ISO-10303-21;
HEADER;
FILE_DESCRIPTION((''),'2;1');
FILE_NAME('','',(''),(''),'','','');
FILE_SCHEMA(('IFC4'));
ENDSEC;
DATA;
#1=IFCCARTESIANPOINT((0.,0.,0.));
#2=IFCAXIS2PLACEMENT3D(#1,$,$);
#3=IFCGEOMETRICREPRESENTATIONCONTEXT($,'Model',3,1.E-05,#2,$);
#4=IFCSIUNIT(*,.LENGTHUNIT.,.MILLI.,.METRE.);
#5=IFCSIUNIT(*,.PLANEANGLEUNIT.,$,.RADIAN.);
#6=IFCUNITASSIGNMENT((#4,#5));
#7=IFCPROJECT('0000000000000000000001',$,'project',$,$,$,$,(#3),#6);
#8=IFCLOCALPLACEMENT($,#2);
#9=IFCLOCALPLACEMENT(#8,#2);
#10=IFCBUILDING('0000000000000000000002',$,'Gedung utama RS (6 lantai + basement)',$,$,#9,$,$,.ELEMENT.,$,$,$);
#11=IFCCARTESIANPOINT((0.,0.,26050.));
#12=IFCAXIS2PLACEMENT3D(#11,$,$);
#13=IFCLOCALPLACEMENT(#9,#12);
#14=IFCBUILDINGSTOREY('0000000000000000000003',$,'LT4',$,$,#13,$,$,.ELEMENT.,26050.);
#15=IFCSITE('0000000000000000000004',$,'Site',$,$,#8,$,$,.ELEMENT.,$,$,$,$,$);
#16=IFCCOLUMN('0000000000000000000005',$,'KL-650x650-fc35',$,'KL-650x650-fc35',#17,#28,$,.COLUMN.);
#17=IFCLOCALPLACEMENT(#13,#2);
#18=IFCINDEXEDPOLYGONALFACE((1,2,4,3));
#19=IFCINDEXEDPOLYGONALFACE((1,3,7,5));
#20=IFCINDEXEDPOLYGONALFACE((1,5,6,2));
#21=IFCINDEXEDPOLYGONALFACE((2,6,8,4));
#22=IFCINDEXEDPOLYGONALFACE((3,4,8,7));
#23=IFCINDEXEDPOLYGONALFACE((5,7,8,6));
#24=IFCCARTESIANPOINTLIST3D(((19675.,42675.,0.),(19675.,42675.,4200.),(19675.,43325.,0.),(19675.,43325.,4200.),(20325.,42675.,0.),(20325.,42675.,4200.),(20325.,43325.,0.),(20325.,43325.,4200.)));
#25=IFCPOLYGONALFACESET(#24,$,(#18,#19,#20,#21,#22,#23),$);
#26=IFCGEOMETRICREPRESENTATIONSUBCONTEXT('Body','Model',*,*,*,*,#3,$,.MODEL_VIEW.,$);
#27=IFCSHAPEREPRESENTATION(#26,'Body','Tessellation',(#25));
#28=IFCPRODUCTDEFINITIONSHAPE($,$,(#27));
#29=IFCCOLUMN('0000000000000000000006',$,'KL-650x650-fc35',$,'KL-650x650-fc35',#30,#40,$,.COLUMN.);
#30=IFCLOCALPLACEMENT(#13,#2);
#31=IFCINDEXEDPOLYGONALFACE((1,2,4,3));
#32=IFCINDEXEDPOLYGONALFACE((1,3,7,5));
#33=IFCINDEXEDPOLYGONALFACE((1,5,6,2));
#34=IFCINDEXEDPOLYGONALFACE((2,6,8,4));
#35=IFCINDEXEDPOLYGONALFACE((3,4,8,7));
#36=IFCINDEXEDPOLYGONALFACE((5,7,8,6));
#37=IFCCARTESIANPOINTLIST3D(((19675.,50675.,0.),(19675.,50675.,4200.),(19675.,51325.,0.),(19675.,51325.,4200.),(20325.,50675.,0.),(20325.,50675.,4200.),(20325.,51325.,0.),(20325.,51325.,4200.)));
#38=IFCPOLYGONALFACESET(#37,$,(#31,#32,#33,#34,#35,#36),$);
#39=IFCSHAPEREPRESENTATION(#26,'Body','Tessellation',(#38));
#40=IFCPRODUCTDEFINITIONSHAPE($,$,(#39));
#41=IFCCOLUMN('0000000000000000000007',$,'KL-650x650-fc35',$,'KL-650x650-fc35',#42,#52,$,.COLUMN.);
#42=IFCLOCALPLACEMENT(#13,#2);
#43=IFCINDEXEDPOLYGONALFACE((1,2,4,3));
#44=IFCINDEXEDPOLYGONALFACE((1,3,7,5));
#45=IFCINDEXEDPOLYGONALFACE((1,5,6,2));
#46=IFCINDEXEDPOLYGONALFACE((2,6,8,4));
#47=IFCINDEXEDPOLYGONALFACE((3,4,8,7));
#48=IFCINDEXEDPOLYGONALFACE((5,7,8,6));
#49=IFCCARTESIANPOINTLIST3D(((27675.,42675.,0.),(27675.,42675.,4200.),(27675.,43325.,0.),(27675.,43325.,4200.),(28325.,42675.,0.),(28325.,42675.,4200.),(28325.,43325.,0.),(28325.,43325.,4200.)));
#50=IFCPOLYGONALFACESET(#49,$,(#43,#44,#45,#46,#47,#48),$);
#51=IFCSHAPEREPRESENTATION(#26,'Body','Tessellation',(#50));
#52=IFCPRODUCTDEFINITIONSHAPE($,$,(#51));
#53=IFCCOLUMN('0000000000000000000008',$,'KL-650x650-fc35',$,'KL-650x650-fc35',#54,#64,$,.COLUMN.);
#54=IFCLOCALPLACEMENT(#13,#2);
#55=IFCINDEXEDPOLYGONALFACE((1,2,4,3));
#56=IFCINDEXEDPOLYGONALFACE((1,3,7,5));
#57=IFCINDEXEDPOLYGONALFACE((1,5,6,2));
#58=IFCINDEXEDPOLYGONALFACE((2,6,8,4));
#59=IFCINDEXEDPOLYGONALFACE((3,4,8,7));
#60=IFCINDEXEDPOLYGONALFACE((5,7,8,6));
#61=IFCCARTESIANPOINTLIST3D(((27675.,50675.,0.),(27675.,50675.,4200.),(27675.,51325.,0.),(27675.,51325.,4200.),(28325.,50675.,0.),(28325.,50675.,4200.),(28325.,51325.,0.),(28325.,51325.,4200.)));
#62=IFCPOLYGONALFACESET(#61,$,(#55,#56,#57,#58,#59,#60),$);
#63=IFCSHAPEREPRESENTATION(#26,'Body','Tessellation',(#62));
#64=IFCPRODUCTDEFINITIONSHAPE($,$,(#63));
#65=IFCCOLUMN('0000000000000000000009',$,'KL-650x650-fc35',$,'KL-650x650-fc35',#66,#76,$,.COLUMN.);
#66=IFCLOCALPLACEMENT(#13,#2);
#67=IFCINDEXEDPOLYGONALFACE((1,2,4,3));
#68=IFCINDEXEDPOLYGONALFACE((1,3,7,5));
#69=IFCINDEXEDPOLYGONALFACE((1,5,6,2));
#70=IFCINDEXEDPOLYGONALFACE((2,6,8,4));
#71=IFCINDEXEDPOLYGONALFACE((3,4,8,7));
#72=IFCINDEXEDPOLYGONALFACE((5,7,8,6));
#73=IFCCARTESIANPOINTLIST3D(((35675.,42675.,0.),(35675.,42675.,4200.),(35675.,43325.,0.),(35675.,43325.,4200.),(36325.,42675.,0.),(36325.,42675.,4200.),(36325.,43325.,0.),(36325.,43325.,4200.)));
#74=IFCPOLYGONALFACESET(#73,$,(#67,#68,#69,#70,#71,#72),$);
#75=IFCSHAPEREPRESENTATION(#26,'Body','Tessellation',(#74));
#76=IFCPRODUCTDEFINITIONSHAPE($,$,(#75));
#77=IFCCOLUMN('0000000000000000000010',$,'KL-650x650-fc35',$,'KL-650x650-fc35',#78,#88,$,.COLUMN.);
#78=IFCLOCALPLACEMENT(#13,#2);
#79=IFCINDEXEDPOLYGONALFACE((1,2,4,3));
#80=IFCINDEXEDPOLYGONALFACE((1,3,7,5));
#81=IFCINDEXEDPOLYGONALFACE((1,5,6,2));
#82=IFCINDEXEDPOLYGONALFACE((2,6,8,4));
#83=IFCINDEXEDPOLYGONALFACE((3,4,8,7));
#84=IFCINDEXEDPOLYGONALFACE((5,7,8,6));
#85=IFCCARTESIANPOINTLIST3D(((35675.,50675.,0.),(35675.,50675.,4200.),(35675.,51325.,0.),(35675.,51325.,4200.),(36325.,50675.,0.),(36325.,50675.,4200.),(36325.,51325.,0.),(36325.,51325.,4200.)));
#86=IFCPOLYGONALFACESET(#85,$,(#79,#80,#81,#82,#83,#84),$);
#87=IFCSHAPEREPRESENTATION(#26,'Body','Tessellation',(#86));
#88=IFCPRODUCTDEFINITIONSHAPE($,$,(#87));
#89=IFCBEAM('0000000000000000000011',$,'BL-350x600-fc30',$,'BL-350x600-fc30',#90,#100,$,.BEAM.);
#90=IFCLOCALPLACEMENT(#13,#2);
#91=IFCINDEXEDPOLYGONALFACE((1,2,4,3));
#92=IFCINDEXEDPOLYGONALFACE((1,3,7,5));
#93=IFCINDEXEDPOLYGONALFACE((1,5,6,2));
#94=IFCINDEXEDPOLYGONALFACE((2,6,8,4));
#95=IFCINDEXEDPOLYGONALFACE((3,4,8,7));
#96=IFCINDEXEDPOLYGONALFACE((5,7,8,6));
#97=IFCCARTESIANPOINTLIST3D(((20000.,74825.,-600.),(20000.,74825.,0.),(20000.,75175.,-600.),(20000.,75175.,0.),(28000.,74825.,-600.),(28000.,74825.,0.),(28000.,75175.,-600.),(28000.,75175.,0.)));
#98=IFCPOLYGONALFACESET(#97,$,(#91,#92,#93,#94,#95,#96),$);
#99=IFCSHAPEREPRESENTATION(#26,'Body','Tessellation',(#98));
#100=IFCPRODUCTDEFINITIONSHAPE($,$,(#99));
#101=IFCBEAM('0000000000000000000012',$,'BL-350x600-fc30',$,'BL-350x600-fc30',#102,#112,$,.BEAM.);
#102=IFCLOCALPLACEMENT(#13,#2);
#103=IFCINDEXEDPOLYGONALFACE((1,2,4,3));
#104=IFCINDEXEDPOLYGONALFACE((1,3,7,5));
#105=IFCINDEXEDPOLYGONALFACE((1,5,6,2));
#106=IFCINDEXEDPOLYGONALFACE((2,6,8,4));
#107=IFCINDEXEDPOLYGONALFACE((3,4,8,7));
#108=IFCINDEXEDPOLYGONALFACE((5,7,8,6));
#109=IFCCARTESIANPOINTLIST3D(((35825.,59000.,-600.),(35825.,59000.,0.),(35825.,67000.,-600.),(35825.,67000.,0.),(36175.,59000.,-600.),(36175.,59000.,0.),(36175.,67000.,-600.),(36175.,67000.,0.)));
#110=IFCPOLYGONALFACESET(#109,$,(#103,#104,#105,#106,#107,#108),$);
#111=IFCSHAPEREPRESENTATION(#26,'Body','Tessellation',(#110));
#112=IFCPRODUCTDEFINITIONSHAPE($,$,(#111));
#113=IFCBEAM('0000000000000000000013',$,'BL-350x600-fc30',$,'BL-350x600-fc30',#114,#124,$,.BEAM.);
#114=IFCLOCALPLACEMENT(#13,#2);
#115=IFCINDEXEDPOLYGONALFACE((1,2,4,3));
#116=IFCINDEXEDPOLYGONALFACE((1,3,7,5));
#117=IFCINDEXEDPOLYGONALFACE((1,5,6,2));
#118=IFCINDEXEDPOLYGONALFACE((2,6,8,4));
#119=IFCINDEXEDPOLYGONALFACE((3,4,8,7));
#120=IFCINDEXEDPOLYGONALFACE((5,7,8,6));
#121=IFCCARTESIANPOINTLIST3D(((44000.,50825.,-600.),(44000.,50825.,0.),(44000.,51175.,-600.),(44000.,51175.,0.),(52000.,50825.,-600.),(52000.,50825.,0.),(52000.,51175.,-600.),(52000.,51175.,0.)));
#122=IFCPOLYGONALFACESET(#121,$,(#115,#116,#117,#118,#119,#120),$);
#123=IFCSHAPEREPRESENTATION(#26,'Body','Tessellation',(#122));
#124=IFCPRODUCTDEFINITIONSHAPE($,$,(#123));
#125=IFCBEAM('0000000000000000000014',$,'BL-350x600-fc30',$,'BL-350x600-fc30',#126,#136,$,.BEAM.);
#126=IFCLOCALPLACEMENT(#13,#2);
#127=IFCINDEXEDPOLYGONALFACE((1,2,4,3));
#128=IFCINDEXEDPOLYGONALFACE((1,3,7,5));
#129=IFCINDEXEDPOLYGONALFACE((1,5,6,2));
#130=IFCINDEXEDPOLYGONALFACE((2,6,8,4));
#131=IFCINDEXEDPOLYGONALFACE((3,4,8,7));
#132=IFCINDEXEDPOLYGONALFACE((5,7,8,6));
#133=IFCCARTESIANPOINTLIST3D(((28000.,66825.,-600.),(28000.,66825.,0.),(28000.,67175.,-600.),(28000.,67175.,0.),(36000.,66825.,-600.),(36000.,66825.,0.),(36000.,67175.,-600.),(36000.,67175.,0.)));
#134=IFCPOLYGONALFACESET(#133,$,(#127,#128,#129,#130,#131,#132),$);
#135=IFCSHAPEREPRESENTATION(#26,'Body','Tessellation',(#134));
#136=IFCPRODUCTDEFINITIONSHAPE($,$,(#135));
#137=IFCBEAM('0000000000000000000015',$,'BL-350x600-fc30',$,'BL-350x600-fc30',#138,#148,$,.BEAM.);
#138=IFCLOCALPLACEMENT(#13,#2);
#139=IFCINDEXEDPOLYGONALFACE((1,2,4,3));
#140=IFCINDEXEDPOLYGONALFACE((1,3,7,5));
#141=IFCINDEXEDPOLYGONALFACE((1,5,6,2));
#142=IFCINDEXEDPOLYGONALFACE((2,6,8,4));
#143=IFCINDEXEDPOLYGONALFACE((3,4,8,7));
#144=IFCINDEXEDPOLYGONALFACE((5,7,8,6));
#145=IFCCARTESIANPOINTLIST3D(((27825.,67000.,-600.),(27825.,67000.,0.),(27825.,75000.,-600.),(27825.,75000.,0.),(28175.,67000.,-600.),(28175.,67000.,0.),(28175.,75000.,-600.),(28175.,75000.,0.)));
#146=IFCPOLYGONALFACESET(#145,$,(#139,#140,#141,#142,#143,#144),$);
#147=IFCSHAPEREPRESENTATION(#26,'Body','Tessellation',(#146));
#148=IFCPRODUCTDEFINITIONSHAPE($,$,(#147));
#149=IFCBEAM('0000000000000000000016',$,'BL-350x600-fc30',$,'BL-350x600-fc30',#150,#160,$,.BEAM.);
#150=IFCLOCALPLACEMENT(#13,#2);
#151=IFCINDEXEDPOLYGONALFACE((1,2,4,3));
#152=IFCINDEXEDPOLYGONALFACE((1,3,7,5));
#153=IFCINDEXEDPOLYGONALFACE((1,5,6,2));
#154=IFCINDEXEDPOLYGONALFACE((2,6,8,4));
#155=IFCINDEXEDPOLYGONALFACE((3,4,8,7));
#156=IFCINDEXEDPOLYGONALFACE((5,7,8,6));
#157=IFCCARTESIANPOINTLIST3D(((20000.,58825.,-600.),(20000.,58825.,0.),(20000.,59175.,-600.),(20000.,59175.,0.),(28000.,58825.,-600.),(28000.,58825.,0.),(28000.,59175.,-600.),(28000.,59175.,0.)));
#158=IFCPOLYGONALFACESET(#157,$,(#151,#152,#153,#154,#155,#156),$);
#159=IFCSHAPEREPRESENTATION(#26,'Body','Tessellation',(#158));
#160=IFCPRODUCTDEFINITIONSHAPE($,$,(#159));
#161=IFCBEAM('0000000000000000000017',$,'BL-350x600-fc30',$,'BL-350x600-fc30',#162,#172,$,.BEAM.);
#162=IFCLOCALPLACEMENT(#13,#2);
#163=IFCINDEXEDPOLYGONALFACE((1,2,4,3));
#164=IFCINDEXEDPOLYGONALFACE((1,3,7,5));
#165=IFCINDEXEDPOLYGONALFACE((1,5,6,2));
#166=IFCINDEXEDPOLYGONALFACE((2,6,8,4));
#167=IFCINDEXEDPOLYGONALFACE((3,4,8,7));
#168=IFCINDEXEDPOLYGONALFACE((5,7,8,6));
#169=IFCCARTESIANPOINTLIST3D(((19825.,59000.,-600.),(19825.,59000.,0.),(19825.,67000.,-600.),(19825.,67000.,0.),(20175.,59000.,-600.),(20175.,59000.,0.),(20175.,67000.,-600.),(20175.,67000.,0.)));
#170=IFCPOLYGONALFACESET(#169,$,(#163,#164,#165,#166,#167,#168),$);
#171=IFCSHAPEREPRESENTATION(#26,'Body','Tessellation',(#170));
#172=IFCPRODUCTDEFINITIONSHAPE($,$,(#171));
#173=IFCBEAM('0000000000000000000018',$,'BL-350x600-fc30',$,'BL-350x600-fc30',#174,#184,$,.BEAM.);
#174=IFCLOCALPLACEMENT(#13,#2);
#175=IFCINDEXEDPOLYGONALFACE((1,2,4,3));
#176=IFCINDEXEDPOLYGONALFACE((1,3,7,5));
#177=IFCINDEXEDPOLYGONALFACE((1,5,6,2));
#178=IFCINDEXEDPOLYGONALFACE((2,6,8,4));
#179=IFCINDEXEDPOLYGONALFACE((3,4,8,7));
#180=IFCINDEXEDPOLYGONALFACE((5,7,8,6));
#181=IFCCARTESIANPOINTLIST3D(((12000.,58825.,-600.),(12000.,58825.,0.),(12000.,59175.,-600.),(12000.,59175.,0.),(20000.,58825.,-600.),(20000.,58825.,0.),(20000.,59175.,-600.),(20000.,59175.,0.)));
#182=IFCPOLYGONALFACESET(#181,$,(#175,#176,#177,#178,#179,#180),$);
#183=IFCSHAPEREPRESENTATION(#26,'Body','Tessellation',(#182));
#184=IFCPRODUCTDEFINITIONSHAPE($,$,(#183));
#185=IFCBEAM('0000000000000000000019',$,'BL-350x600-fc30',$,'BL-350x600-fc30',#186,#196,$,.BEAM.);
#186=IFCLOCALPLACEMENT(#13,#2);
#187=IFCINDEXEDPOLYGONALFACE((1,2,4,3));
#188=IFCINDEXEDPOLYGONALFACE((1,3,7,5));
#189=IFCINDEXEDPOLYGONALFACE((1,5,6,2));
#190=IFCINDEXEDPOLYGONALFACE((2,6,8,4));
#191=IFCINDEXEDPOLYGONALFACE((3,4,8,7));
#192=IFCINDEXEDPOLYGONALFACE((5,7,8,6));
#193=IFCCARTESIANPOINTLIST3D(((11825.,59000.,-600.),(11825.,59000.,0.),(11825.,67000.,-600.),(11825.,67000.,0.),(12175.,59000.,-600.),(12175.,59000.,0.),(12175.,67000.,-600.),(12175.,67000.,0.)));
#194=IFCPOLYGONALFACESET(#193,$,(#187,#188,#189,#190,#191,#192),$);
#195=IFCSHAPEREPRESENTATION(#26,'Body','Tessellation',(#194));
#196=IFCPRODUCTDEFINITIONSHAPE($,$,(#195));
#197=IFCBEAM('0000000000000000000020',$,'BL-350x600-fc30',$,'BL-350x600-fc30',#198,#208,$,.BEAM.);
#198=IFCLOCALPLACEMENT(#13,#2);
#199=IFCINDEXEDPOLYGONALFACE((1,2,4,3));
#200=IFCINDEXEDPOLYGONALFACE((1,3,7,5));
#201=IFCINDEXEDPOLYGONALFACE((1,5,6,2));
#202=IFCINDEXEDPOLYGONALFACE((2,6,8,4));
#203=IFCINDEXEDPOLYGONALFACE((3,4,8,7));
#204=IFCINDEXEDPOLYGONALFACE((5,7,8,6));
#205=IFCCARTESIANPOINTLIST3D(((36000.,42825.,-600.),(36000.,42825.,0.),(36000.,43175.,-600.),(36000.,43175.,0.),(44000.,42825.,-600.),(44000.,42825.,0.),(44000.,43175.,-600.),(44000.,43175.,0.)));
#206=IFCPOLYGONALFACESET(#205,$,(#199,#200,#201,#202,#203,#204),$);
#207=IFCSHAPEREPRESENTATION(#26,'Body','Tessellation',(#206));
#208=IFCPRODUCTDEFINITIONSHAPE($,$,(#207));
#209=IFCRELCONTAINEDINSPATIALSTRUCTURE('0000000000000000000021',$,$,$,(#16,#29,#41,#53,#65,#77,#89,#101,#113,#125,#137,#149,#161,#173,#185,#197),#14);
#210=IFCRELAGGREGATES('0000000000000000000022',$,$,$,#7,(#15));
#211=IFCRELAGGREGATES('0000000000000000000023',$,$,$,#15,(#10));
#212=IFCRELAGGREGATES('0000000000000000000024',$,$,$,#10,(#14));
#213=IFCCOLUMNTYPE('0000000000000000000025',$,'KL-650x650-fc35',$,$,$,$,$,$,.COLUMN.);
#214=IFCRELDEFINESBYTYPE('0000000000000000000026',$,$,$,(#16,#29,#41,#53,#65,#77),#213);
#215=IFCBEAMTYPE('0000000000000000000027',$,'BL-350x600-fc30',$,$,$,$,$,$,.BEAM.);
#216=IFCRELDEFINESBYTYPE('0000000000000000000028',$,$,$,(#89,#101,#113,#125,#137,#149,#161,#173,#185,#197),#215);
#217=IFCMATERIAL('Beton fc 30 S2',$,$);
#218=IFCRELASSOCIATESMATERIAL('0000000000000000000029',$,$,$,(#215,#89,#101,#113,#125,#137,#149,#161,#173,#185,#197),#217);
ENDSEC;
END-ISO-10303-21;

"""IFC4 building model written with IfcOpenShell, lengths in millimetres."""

from ifc_helpers import new_model, si_unit, frame, origin, origin_2d, place, context, subcontext, project, spatial, rectangle, extrude, material, material_profile, profile_set, profile_usage, type_object, element, save


model = new_model("IFC4")

# Units and contexts
model_context = context("Model", 3, precision=1e-05, world=origin())
body_context = subcontext(model_context, "Body", "Model", "MODEL_VIEW")
ifc_project = project(units=[si_unit("LENGTHUNIT", "METRE", prefix="MILLI"), si_unit("PLANEANGLEUNIT", "RADIAN")], contexts=[model_context])

# Site, building, storey
site_placement = place(None, origin())
site = spatial("IfcSite", under=ifc_project, at=site_placement, Name="Site", CompositionType="ELEMENT")
building_placement = place(site_placement, origin())
building = spatial("IfcBuilding", under=site, at=building_placement, Name="Gedung utama RS (6 lantai + basement)", CompositionType="ELEMENT")
storey_placement = place(building_placement, frame((0.0, 0.0, 26050.0)))
storey = spatial("IfcBuildingStorey", under=building, at=storey_placement, Name="LT4", CompositionType="ELEMENT", Elevation=26050.0)

# Columns
ifc_material_profile_1 = material_profile(None, rectangle(XDim=650.0, YDim=650.0, at=origin_2d()), Name="KL-650x650-fc35")
ifc_profile_set_1 = profile_set([ifc_material_profile_1], Name="KL-650x650-fc35")
ifc_profile_usage_1 = profile_usage(ifc_profile_set_1, cardinal=5)
column_type = type_object("IfcColumnType", Name="KL-650x650-fc35", PredefinedType="COLUMN", material=ifc_profile_set_1)
for number, where, z_axis, x_axis, name in (
    (1, (20000.0, 43000.0, 0.0), (0.0, 0.0, 1.0), (1.0, 0.0, 0.0), "KL-650x650-fc35"),
    (2, (20000.0, 51000.0, 0.0), (0.0, 0.0, 1.0), (1.0, 0.0, 0.0), "KL-650x650-fc35"),
    (3, (28000.0, 43000.0, 0.0), (0.0, 0.0, 1.0), (1.0, 0.0, 0.0), "KL-650x650-fc35"),
    (4, (28000.0, 51000.0, 0.0), (0.0, 0.0, 1.0), (1.0, 0.0, 0.0), "KL-650x650-fc35"),
    (5, (36000.0, 43000.0, 0.0), (0.0, 0.0, 1.0), (1.0, 0.0, 0.0), "KL-650x650-fc35"),
    (6, (36000.0, 51000.0, 0.0), (0.0, 0.0, 1.0), (1.0, 0.0, 0.0), "KL-650x650-fc35"),
):
    element("IfcColumn", number, at=place(storey_placement, frame(where, z_axis=z_axis, x_axis=x_axis)), inside=storey, type_object=column_type, material=ifc_profile_usage_1, Name=name, ObjectType="KL-650x650-fc35", PredefinedType="COLUMN", context=body_context, shape_type="SweptSolid", body=[
        extrude(rectangle(XDim=650.0, YDim=650.0, at=origin_2d()), origin(), (0.0, 0.0, 1.0), 4200.0),
    ])

# Beams
ifc_material = material(Name="Beton fc 30 S2")
ifc_material_profile_2 = material_profile(ifc_material, rectangle(XDim=350.0, YDim=600.0, at=origin_2d()), Name="BL-350x600-fc30")
ifc_profile_set_2 = profile_set([ifc_material_profile_2], Name="BL-350x600-fc30")
ifc_profile_usage_2 = profile_usage(ifc_profile_set_2, cardinal=8)
beam_type = type_object("IfcBeamType", Name="BL-350x600-fc30", PredefinedType="BEAM", material=ifc_profile_set_2)
beam_1_placement = place(storey_placement, frame((20000.0, 75000.0, -300.0)))
element("IfcBeam", 7, at=beam_1_placement, inside=storey, type_object=beam_type, material=ifc_profile_usage_2, Name="BL-350x600-fc30", ObjectType="BL-350x600-fc30", PredefinedType="BEAM", context=body_context, shape_type="SweptSolid", body=[
    extrude(rectangle(XDim=350.0, YDim=600.0, at=origin_2d()), frame((0.0, 0.0, 0.0), z_axis=(1.0, 0.0, 0.0), x_axis=(0.0, 1.0, 0.0)), (0.0, 0.0, 1.0), 8000.0),
])
beam_2_placement = place(storey_placement, frame((36000.0, 59000.0, -300.0)))
element("IfcBeam", 8, at=beam_2_placement, inside=storey, type_object=beam_type, material=ifc_profile_usage_2, Name="BL-350x600-fc30", ObjectType="BL-350x600-fc30", PredefinedType="BEAM", context=body_context, shape_type="SweptSolid", body=[
    extrude(rectangle(XDim=350.0, YDim=600.0, at=origin_2d()), frame((0.0, 0.0, 0.0), z_axis=(0.0, 1.0, 0.0), x_axis=(-1.0, 0.0, 0.0)), (0.0, 0.0, 1.0), 8000.0),
])
for number, where, name in (
    (9, (44000.0, 51000.0, -300.0), "BL-350x600-fc30"),
    (10, (28000.0, 67000.0, -300.0), "BL-350x600-fc30"),
):
    element("IfcBeam", number, at=place(storey_placement, frame(where)), inside=storey, type_object=beam_type, material=ifc_profile_usage_2, Name=name, ObjectType="BL-350x600-fc30", PredefinedType="BEAM", context=body_context, shape_type="SweptSolid", body=[
        extrude(rectangle(XDim=350.0, YDim=600.0, at=origin_2d()), frame((0.0, 0.0, 0.0), z_axis=(1.0, 0.0, 0.0), x_axis=(0.0, 1.0, 0.0)), (0.0, 0.0, 1.0), 8000.0),
    ])
beam_3_placement = place(storey_placement, frame((28000.0, 67000.0, -300.0)))
element("IfcBeam", 11, at=beam_3_placement, inside=storey, type_object=beam_type, material=ifc_profile_usage_2, Name="BL-350x600-fc30", ObjectType="BL-350x600-fc30", PredefinedType="BEAM", context=body_context, shape_type="SweptSolid", body=[
    extrude(rectangle(XDim=350.0, YDim=600.0, at=origin_2d()), frame((0.0, 0.0, 0.0), z_axis=(0.0, 1.0, 0.0), x_axis=(-1.0, 0.0, 0.0)), (0.0, 0.0, 1.0), 8000.0),
])
beam_4_placement = place(storey_placement, frame((20000.0, 59000.0, -300.0)))
element("IfcBeam", 12, at=beam_4_placement, inside=storey, type_object=beam_type, material=ifc_profile_usage_2, Name="BL-350x600-fc30", ObjectType="BL-350x600-fc30", PredefinedType="BEAM", context=body_context, shape_type="SweptSolid", body=[
    extrude(rectangle(XDim=350.0, YDim=600.0, at=origin_2d()), frame((0.0, 0.0, 0.0), z_axis=(1.0, 0.0, 0.0), x_axis=(0.0, 1.0, 0.0)), (0.0, 0.0, 1.0), 8000.0),
])
beam_5_placement = place(storey_placement, frame((20000.0, 59000.0, -300.0)))
element("IfcBeam", 13, at=beam_5_placement, inside=storey, type_object=beam_type, material=ifc_profile_usage_2, Name="BL-350x600-fc30", ObjectType="BL-350x600-fc30", PredefinedType="BEAM", context=body_context, shape_type="SweptSolid", body=[
    extrude(rectangle(XDim=350.0, YDim=600.0, at=origin_2d()), frame((0.0, 0.0, 0.0), z_axis=(0.0, 1.0, 0.0), x_axis=(-1.0, 0.0, 0.0)), (0.0, 0.0, 1.0), 8000.0),
])
beam_6_placement = place(storey_placement, frame((12000.0, 59000.0, -300.0)))
element("IfcBeam", 14, at=beam_6_placement, inside=storey, type_object=beam_type, material=ifc_profile_usage_2, Name="BL-350x600-fc30", ObjectType="BL-350x600-fc30", PredefinedType="BEAM", context=body_context, shape_type="SweptSolid", body=[
    extrude(rectangle(XDim=350.0, YDim=600.0, at=origin_2d()), frame((0.0, 0.0, 0.0), z_axis=(1.0, 0.0, 0.0), x_axis=(0.0, 1.0, 0.0)), (0.0, 0.0, 1.0), 8000.0),
])
beam_7_placement = place(storey_placement, frame((12000.0, 59000.0, -300.0)))
element("IfcBeam", 15, at=beam_7_placement, inside=storey, type_object=beam_type, material=ifc_profile_usage_2, Name="BL-350x600-fc30", ObjectType="BL-350x600-fc30", PredefinedType="BEAM", context=body_context, shape_type="SweptSolid", body=[
    extrude(rectangle(XDim=350.0, YDim=600.0, at=origin_2d()), frame((0.0, 0.0, 0.0), z_axis=(0.0, 1.0, 0.0), x_axis=(-1.0, 0.0, 0.0)), (0.0, 0.0, 1.0), 8000.0),
])
beam_8_placement = place(storey_placement, frame((36000.0, 43000.0, -300.0)))
element("IfcBeam", 16, at=beam_8_placement, inside=storey, type_object=beam_type, material=ifc_profile_usage_2, Name="BL-350x600-fc30", ObjectType="BL-350x600-fc30", PredefinedType="BEAM", context=body_context, shape_type="SweptSolid", body=[
    extrude(rectangle(XDim=350.0, YDim=600.0, at=origin_2d()), frame((0.0, 0.0, 0.0), z_axis=(1.0, 0.0, 0.0), x_axis=(0.0, 1.0, 0.0)), (0.0, 0.0, 1.0), 8000.0),
])

save(model, "model.ifc")
